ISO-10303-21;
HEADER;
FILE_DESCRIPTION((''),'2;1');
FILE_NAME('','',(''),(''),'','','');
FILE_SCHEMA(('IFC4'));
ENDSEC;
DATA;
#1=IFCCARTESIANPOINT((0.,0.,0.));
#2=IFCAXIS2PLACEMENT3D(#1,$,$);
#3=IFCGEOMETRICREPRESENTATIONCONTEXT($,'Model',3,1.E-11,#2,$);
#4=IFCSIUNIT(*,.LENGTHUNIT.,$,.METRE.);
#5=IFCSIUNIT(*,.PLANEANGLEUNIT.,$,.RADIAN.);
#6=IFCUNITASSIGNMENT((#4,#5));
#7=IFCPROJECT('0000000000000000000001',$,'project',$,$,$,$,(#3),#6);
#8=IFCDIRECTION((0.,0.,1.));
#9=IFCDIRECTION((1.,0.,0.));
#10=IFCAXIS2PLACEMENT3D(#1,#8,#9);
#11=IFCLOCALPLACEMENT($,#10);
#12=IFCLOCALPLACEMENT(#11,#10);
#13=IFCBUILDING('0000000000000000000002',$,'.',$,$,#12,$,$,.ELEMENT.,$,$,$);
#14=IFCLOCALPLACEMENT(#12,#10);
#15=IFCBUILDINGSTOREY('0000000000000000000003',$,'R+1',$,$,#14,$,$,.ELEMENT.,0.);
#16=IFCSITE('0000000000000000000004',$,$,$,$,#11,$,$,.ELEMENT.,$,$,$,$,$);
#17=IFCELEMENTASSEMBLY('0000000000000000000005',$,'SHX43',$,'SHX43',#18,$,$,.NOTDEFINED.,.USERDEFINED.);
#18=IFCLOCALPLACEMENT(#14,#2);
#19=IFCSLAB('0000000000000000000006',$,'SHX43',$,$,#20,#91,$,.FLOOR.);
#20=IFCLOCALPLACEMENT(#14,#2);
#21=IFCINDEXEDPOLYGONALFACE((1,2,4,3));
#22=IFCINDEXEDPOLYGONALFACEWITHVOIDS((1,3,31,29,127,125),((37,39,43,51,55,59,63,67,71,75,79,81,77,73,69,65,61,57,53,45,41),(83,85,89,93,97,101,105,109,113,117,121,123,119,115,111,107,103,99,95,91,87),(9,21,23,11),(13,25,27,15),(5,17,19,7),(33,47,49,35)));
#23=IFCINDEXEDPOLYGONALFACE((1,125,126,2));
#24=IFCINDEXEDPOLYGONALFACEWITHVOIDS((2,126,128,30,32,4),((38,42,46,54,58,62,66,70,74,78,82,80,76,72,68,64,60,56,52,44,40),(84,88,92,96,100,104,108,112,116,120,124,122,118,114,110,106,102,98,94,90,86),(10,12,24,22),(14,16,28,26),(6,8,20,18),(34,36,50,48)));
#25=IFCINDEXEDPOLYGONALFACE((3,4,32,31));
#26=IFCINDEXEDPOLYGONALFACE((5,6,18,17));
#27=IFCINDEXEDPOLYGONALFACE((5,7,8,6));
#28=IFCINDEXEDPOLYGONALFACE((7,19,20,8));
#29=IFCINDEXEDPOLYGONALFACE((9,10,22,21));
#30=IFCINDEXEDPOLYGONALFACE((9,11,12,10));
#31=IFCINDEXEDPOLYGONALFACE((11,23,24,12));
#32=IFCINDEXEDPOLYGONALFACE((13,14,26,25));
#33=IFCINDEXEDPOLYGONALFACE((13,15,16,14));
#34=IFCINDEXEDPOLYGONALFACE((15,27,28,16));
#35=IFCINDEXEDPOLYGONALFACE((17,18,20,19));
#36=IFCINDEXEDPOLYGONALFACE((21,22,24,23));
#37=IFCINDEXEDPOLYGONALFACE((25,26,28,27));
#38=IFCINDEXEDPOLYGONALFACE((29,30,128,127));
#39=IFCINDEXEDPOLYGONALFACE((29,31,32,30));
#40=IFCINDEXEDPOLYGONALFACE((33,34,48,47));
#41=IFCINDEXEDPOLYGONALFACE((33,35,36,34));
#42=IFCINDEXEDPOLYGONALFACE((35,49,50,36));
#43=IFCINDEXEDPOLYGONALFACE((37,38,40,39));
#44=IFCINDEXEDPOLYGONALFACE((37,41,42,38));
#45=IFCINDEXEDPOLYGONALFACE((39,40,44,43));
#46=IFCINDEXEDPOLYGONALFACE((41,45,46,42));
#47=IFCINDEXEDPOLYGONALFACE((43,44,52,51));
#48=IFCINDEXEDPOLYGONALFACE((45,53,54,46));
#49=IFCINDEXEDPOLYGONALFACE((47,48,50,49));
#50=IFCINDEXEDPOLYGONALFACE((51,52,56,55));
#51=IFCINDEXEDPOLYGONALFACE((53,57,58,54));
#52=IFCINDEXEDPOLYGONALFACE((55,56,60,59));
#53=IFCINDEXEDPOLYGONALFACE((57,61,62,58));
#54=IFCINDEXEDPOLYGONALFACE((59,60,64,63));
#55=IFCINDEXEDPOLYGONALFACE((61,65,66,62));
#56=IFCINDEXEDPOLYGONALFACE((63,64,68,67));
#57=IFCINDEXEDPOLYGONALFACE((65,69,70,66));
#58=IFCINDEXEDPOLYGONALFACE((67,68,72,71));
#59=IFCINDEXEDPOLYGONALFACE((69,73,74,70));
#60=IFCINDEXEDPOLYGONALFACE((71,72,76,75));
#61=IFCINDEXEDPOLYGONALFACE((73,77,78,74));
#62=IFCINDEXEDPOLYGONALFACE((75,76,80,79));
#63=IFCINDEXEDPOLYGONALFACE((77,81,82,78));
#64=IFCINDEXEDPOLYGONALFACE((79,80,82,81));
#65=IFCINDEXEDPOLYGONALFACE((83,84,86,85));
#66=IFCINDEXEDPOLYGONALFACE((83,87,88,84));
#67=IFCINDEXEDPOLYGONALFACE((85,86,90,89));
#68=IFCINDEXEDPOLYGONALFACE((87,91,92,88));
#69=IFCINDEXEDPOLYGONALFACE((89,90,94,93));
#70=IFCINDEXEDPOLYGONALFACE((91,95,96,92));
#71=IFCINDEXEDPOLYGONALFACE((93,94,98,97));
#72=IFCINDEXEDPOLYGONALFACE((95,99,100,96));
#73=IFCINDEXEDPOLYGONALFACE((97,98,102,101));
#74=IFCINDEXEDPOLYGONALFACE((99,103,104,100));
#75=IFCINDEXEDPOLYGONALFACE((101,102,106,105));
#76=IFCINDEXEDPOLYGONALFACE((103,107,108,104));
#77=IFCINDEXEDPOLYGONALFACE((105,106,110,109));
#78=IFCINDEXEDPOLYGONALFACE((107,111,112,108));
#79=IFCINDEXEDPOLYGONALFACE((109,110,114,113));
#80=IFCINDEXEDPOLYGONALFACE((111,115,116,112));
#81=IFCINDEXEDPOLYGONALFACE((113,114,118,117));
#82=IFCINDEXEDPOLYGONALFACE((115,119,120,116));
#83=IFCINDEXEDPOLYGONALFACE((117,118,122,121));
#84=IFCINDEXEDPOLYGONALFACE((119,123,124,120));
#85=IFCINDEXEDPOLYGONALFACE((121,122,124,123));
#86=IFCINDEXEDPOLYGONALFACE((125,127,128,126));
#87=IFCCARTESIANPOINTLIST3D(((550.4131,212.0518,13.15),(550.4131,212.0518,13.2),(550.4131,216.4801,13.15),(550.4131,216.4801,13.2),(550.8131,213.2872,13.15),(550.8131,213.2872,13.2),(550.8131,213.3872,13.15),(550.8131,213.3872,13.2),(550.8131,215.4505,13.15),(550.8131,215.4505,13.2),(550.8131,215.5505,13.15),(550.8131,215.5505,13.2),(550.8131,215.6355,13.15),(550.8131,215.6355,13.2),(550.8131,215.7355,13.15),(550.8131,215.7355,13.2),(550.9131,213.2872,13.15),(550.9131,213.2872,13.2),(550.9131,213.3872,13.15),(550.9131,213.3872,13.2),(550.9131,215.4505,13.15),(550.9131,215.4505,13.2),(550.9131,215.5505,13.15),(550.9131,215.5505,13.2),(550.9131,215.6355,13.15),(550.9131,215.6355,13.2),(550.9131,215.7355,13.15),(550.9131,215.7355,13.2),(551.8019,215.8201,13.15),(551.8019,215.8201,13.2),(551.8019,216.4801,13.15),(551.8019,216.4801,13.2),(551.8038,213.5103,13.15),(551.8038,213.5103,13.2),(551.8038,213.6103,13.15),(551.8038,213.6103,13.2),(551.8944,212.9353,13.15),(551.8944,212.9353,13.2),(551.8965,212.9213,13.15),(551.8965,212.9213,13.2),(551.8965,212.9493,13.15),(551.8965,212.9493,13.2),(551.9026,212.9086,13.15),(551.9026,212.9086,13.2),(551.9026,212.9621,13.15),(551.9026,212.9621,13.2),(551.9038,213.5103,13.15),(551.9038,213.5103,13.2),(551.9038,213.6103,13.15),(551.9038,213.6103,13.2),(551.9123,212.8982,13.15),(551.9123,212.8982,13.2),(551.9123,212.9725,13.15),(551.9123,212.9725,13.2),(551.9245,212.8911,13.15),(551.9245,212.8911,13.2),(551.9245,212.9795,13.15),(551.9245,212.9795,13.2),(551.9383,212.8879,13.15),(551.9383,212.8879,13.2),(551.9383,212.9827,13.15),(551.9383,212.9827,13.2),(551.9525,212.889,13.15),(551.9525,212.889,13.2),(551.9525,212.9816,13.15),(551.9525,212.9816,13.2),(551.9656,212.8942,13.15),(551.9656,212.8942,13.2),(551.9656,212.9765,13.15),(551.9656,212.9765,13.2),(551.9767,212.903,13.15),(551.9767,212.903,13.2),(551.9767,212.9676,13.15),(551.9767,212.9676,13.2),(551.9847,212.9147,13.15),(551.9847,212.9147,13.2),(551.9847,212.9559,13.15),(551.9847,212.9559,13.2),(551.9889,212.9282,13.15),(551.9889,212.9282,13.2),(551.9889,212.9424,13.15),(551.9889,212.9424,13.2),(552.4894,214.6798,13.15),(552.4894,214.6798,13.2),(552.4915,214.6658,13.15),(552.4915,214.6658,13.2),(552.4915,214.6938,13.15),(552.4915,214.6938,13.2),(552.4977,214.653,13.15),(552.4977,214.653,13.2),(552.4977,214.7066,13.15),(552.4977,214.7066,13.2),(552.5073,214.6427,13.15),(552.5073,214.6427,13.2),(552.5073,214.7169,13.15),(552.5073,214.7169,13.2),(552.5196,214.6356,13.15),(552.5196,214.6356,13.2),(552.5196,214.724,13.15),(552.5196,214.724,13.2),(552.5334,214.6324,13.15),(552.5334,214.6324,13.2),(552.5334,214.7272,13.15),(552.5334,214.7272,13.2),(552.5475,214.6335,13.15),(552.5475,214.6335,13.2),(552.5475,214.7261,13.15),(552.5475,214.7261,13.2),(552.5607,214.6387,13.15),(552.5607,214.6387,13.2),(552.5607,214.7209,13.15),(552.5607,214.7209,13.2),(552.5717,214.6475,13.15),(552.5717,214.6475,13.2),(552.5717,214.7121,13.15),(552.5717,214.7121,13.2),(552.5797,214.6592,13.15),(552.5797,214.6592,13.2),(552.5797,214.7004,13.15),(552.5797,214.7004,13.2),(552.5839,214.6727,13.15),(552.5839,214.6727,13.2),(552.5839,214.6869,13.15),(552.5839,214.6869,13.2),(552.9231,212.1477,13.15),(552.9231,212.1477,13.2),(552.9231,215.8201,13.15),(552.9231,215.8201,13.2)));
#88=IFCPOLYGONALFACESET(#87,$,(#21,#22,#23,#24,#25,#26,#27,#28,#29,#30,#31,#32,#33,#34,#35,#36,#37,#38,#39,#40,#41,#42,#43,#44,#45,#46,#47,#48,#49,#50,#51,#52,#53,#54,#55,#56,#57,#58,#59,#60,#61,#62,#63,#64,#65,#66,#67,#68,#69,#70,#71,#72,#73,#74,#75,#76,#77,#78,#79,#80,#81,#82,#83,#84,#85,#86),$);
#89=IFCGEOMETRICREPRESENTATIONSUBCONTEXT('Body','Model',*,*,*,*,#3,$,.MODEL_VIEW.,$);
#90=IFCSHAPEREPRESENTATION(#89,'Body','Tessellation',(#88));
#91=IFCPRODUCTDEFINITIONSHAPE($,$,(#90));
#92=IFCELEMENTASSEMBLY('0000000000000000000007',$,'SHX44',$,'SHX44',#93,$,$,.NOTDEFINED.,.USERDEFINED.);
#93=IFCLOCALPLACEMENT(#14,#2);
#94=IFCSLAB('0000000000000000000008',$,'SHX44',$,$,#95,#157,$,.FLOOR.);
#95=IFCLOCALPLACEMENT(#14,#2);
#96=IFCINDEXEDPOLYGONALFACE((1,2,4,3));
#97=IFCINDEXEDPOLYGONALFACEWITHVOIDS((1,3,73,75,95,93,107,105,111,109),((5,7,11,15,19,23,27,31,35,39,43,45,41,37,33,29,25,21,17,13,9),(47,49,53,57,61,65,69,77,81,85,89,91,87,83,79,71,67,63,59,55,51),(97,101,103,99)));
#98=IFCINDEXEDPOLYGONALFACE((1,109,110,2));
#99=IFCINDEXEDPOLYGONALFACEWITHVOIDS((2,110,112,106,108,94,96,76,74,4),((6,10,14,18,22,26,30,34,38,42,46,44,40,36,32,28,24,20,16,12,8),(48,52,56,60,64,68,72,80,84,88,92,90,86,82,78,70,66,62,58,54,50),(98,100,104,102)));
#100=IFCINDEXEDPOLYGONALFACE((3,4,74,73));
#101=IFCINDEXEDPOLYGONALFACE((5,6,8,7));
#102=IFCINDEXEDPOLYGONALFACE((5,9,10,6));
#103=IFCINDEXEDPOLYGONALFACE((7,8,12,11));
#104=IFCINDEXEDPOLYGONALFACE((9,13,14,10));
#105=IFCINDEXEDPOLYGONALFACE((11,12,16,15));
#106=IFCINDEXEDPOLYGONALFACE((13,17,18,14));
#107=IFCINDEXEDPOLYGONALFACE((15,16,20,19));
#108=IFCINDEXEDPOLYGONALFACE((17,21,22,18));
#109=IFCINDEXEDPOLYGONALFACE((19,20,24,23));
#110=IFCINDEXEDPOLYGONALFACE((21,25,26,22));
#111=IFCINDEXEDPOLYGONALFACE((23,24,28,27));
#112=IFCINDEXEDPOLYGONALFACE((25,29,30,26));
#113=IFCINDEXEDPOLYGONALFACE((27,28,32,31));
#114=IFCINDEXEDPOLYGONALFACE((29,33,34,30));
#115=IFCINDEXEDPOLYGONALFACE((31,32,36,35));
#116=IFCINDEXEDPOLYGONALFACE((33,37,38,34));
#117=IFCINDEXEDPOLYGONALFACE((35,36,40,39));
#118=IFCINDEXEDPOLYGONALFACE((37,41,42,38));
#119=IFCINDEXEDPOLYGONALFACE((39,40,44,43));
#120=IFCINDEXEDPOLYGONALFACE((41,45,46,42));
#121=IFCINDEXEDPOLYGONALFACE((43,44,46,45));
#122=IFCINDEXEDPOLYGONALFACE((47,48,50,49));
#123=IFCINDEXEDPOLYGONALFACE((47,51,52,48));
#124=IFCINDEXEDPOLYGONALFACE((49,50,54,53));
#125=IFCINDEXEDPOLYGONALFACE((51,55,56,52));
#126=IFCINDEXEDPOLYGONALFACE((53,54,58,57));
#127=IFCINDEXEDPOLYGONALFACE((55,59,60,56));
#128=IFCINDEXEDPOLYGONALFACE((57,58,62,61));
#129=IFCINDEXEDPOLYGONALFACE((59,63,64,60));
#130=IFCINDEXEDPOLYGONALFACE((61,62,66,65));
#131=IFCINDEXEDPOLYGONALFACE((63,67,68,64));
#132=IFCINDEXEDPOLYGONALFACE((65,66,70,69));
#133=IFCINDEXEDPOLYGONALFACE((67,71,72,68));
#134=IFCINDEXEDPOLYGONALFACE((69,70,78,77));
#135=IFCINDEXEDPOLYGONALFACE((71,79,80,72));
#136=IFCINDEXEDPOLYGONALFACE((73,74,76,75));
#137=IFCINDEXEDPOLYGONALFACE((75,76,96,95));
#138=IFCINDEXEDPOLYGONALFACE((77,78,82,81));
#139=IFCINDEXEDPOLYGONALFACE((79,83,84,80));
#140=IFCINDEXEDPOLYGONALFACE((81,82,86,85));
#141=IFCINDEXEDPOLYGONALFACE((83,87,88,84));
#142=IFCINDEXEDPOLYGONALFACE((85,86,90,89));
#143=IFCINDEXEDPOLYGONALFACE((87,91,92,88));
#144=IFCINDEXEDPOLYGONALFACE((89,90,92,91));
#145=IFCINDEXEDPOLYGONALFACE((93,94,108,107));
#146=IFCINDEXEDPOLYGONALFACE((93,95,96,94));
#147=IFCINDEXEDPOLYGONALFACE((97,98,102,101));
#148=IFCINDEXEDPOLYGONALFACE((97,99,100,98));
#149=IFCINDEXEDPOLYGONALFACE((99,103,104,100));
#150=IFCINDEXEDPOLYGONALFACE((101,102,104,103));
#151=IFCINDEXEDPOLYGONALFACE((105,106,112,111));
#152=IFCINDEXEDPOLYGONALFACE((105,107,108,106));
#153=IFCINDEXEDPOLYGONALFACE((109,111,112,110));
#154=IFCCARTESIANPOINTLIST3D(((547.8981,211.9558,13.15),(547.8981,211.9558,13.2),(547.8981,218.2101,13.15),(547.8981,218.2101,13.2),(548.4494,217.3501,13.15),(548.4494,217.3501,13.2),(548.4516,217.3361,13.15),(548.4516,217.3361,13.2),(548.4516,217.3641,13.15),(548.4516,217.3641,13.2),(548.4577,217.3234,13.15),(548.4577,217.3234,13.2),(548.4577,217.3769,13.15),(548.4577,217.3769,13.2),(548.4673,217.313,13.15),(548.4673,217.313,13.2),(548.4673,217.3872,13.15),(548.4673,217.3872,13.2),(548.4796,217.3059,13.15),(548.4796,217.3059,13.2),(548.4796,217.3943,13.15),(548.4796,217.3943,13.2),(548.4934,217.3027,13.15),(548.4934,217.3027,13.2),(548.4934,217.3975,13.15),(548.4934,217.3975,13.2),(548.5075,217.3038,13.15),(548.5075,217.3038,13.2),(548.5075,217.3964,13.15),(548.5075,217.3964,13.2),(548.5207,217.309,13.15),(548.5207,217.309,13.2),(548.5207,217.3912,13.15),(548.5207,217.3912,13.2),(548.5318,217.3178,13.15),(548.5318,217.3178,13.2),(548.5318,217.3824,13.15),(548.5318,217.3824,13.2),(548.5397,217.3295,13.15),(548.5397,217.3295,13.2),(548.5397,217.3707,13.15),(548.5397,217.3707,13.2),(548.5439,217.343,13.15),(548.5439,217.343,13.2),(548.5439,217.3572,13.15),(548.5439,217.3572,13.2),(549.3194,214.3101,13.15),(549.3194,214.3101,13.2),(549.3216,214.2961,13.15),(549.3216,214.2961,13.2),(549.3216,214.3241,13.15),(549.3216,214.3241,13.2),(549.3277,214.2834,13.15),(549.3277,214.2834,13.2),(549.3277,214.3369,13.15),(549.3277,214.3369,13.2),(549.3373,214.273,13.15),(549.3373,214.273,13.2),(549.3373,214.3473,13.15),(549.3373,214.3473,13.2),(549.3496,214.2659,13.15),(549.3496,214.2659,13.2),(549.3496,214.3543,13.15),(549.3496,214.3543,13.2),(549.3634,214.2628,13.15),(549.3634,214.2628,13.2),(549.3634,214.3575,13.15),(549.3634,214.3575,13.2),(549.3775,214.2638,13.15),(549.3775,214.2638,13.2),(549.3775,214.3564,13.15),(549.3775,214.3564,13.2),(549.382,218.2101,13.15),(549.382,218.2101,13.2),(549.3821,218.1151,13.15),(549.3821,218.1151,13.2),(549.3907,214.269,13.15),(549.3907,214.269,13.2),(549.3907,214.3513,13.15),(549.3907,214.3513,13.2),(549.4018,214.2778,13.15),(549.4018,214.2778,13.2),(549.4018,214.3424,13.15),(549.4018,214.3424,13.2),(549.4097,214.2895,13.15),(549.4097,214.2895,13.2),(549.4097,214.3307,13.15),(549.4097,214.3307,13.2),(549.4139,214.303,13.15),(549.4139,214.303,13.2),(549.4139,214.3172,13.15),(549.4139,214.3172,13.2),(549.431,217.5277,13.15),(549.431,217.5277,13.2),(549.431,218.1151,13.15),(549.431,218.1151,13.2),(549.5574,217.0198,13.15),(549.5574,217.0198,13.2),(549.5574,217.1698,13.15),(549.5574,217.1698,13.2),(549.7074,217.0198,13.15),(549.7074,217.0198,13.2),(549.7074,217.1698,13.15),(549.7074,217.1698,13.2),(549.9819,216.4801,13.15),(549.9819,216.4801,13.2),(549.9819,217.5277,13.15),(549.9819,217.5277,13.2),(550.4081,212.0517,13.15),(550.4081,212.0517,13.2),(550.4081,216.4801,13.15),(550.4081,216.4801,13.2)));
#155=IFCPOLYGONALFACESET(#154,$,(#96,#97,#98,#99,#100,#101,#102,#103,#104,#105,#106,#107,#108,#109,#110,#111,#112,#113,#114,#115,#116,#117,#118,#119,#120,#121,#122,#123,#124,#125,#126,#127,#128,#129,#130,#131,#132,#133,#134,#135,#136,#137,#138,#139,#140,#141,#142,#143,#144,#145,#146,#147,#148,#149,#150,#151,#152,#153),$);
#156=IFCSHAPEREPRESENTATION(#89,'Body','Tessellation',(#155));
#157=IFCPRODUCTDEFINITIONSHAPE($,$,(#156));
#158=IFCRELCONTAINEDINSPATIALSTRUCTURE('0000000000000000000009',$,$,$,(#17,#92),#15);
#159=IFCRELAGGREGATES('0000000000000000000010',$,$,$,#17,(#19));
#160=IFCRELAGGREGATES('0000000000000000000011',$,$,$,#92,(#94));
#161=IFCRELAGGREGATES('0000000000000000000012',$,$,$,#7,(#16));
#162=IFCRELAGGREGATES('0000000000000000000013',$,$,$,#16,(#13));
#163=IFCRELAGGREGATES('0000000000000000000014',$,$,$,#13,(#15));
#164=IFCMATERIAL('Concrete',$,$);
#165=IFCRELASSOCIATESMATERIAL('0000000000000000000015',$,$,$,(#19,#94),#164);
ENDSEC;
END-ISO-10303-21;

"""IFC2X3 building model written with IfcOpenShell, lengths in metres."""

from ifc_helpers import new_model, si_unit, frame, origin, origin_with_axes, origin_2d_with_axis, place, context, subcontext, project, spatial, polyline, circle, outline, extrude, material, element, aggregate, save


model = new_model("IFC2X3")

# Units and contexts
model_context = context("Model", 3, precision=1e-11, world=origin())
body_context = subcontext(model_context, "Body", "Model", "MODEL_VIEW")
ifc_project = project(units=[si_unit("LENGTHUNIT", "METRE"), si_unit("PLANEANGLEUNIT", "RADIAN")], contexts=[model_context])

# Site, building, storey
site_placement = place(None, origin_with_axes())
site = spatial("IfcSite", under=ifc_project, at=site_placement, CompositionType="ELEMENT")
building_placement = place(site_placement, origin_with_axes())
building = spatial("IfcBuilding", under=site, at=building_placement, Name=".", CompositionType="ELEMENT")
storey_placement = place(building_placement, origin_with_axes())
storey = spatial("IfcBuildingStorey", under=building, at=storey_placement, Name="R+1", CompositionType="ELEMENT", Elevation=0.0)

# Element assemblies, slabs, openings
assembly_1_placement = place(storey_placement, origin_with_axes())
assembly_1 = element("IfcElementAssembly", 1, at=assembly_1_placement, inside=storey, Name="SHX43", ObjectType="SHX43", AssemblyPlace="NOTDEFINED", PredefinedType="USERDEFINED")
ifc_material = material(Name="Concrete")
slab_1_placement = place(assembly_1_placement, frame((552.9231, 212.0518, 13.15), z_axis=(0.0, 0.0, 1.0), x_axis=(0.0, 1.0, 0.0)))
slab_1 = element("IfcSlab", 2, at=slab_1_placement, material=ifc_material, Name="SHX43", PredefinedType="FLOOR", context=body_context, shape_type="SweptSolid", body=[
    extrude(outline(polyline([(0.0, -0.0958), (0.0, -3.7683), (1.1212, -3.7683), (1.1212, -4.4283), (2.51, -4.4283), (2.51, 0.0), (0.0, -0.0958)])), frame((0.0, 0.0, 0.0), z_axis=(0.0, 0.0, 1.0), x_axis=(0.0, 1.0, 0.0)), (0.0, 0.0, 1.0), 0.05),
])
opening_1_placement = place(slab_1_placement, frame((2.6279, 0.3861, 0.0), z_axis=(0.0, 0.0, 1.0), x_axis=(1.0, 0.0, 0.0)))
element("IfcOpeningElement", 3, at=opening_1_placement, cuts=slab_1, ObjectType="Opening", context=body_context, shape_type="SweptSolid", body=[
    extrude(circle(Radius=0.0475, at=origin_2d_with_axis()), frame((0.0, 0.0, 0.0), z_axis=(0.0, 0.0, 1.0), x_axis=(0.0, 1.0, 0.0)), (0.0, 0.0, 1.0), 0.05),
])
opening_2_placement = place(slab_1_placement, frame((0.8835, 0.9812, 0.0), z_axis=(0.0, 0.0, 1.0), x_axis=(1.0, 0.0, 0.0)))
element("IfcOpeningElement", 4, at=opening_2_placement, cuts=slab_1, ObjectType="Opening", context=body_context, shape_type="SweptSolid", body=[
    extrude(circle(Radius=0.0475, at=origin_2d_with_axis()), frame((0.0, 0.0, 0.0), z_axis=(0.0, 0.0, 1.0), x_axis=(0.0, 1.0, 0.0)), (0.0, 0.0, 1.0), 0.05),
])
opening_3_placement = place(slab_1_placement, origin_with_axes())
element("IfcOpeningElement", 5, at=opening_3_placement, cuts=slab_1, ObjectType="Opening", context=body_context, shape_type="SweptSolid", body=[
    extrude(outline(polyline([(1.0193, -1.4585), (1.0193, -1.5585), (1.1193, -1.5585), (1.1193, -1.4585), (1.0193, -1.4585)])), frame((0.0, 0.0, 0.0), z_axis=(0.0, 0.0, 1.0), x_axis=(0.0, 1.0, 0.0)), (0.0, 0.0, 1.0), 0.05),
])
opening_4_placement = place(slab_1_placement, origin_with_axes())
element("IfcOpeningElement", 6, at=opening_4_placement, cuts=slab_1, ObjectType="Opening", context=body_context, shape_type="SweptSolid", body=[
    extrude(outline(polyline([(2.01, -1.2353), (2.01, -1.3353), (2.11, -1.3353), (2.11, -1.2353), (2.01, -1.2353)])), frame((0.0, 0.0, 0.0), z_axis=(0.0, 0.0, 1.0), x_axis=(0.0, 1.0, 0.0)), (0.0, 0.0, 1.0), 0.05),
])
opening_5_placement = place(slab_1_placement, origin_with_axes())
element("IfcOpeningElement", 7, at=opening_5_placement, cuts=slab_1, ObjectType="Opening", context=body_context, shape_type="SweptSolid", body=[
    extrude(outline(polyline([(2.01, -3.3986), (2.01, -3.4986), (2.11, -3.4986), (2.11, -3.3986), (2.01, -3.3986)])), frame((0.0, 0.0, 0.0), z_axis=(0.0, 0.0, 1.0), x_axis=(0.0, 1.0, 0.0)), (0.0, 0.0, 1.0), 0.05),
])
opening_6_placement = place(slab_1_placement, origin_with_axes())
element("IfcOpeningElement", 8, at=opening_6_placement, cuts=slab_1, ObjectType="Opening", context=body_context, shape_type="SweptSolid", body=[
    extrude(outline(polyline([(2.01, -3.5836), (2.01, -3.6836), (2.11, -3.6836), (2.11, -3.5836), (2.01, -3.5836)])), frame((0.0, 0.0, 0.0), z_axis=(0.0, 0.0, 1.0), x_axis=(0.0, 1.0, 0.0)), (0.0, 0.0, 1.0), 0.05),
])
assembly_2_placement = place(storey_placement, origin_with_axes())
assembly_2 = element("IfcElementAssembly", 9, at=assembly_2_placement, inside=storey, Name="SHX44", ObjectType="SHX44", AssemblyPlace="NOTDEFINED", PredefinedType="USERDEFINED")
slab_2_placement = place(assembly_2_placement, frame((550.4081, 211.9558, 13.15), z_axis=(0.0, 0.0, 1.0), x_axis=(0.0, 1.0, 0.0)))
slab_2 = element("IfcSlab", 10, at=slab_2_placement, material=ifc_material, Name="SHX44", PredefinedType="FLOOR", context=body_context, shape_type="SweptSolid", body=[
    extrude(outline(polyline([(0.0, -0.0958), (0.0, -4.5243), (0.4262, -4.5243), (0.4262, -5.5719), (0.9771, -5.5719), (0.9771, -6.1593), (1.026, -6.1593), (1.0261, -6.2543), (2.51, -6.2543), (2.51, 0.0), (0.0, -0.0958)])), frame((0.0, 0.0, 0.0), z_axis=(0.0, 0.0, 1.0), x_axis=(0.0, 1.0, 0.0)), (0.0, 0.0, 1.0), 0.05),
])
opening_7_placement = place(slab_2_placement, origin_with_axes())
element("IfcOpeningElement", 11, at=opening_7_placement, cuts=slab_2, ObjectType="Opening", context=body_context, shape_type="SweptSolid", body=[
    extrude(outline(polyline([(0.7007, -5.064), (0.7007, -5.214), (0.8507, -5.214), (0.8507, -5.064), (0.7007, -5.064)])), frame((0.0, 0.0, 0.0), z_axis=(0.0, 0.0, 1.0), x_axis=(0.0, 1.0, 0.0)), (0.0, 0.0, 1.0), 0.05),
])
opening_8_placement = place(slab_2_placement, frame((2.3543, 1.0411, 0.0), z_axis=(0.0, 0.0, 1.0), x_axis=(1.0, 0.0, 0.0)))
element("IfcOpeningElement", 12, at=opening_8_placement, cuts=slab_2, ObjectType="Opening", context=body_context, shape_type="SweptSolid", body=[
    extrude(circle(Radius=0.0475, at=origin_2d_with_axis()), frame((0.0, 0.0, 0.0), z_axis=(0.0, 0.0, 1.0), x_axis=(0.0, 1.0, 0.0)), (0.0, 0.0, 1.0), 0.05),
])
opening_9_placement = place(slab_2_placement, frame((5.3943, 1.9111, 0.0), z_axis=(0.0, 0.0, 1.0), x_axis=(1.0, 0.0, 0.0)))
element("IfcOpeningElement", 13, at=opening_9_placement, cuts=slab_2, ObjectType="Opening", context=body_context, shape_type="SweptSolid", body=[
    extrude(circle(Radius=0.0475, at=origin_2d_with_axis()), frame((0.0, 0.0, 0.0), z_axis=(0.0, 0.0, 1.0), x_axis=(0.0, 1.0, 0.0)), (0.0, 0.0, 1.0), 0.05),
])

aggregate(assembly_1, [slab_1])

aggregate(assembly_2, [slab_2])

save(model, "model.ifc")
